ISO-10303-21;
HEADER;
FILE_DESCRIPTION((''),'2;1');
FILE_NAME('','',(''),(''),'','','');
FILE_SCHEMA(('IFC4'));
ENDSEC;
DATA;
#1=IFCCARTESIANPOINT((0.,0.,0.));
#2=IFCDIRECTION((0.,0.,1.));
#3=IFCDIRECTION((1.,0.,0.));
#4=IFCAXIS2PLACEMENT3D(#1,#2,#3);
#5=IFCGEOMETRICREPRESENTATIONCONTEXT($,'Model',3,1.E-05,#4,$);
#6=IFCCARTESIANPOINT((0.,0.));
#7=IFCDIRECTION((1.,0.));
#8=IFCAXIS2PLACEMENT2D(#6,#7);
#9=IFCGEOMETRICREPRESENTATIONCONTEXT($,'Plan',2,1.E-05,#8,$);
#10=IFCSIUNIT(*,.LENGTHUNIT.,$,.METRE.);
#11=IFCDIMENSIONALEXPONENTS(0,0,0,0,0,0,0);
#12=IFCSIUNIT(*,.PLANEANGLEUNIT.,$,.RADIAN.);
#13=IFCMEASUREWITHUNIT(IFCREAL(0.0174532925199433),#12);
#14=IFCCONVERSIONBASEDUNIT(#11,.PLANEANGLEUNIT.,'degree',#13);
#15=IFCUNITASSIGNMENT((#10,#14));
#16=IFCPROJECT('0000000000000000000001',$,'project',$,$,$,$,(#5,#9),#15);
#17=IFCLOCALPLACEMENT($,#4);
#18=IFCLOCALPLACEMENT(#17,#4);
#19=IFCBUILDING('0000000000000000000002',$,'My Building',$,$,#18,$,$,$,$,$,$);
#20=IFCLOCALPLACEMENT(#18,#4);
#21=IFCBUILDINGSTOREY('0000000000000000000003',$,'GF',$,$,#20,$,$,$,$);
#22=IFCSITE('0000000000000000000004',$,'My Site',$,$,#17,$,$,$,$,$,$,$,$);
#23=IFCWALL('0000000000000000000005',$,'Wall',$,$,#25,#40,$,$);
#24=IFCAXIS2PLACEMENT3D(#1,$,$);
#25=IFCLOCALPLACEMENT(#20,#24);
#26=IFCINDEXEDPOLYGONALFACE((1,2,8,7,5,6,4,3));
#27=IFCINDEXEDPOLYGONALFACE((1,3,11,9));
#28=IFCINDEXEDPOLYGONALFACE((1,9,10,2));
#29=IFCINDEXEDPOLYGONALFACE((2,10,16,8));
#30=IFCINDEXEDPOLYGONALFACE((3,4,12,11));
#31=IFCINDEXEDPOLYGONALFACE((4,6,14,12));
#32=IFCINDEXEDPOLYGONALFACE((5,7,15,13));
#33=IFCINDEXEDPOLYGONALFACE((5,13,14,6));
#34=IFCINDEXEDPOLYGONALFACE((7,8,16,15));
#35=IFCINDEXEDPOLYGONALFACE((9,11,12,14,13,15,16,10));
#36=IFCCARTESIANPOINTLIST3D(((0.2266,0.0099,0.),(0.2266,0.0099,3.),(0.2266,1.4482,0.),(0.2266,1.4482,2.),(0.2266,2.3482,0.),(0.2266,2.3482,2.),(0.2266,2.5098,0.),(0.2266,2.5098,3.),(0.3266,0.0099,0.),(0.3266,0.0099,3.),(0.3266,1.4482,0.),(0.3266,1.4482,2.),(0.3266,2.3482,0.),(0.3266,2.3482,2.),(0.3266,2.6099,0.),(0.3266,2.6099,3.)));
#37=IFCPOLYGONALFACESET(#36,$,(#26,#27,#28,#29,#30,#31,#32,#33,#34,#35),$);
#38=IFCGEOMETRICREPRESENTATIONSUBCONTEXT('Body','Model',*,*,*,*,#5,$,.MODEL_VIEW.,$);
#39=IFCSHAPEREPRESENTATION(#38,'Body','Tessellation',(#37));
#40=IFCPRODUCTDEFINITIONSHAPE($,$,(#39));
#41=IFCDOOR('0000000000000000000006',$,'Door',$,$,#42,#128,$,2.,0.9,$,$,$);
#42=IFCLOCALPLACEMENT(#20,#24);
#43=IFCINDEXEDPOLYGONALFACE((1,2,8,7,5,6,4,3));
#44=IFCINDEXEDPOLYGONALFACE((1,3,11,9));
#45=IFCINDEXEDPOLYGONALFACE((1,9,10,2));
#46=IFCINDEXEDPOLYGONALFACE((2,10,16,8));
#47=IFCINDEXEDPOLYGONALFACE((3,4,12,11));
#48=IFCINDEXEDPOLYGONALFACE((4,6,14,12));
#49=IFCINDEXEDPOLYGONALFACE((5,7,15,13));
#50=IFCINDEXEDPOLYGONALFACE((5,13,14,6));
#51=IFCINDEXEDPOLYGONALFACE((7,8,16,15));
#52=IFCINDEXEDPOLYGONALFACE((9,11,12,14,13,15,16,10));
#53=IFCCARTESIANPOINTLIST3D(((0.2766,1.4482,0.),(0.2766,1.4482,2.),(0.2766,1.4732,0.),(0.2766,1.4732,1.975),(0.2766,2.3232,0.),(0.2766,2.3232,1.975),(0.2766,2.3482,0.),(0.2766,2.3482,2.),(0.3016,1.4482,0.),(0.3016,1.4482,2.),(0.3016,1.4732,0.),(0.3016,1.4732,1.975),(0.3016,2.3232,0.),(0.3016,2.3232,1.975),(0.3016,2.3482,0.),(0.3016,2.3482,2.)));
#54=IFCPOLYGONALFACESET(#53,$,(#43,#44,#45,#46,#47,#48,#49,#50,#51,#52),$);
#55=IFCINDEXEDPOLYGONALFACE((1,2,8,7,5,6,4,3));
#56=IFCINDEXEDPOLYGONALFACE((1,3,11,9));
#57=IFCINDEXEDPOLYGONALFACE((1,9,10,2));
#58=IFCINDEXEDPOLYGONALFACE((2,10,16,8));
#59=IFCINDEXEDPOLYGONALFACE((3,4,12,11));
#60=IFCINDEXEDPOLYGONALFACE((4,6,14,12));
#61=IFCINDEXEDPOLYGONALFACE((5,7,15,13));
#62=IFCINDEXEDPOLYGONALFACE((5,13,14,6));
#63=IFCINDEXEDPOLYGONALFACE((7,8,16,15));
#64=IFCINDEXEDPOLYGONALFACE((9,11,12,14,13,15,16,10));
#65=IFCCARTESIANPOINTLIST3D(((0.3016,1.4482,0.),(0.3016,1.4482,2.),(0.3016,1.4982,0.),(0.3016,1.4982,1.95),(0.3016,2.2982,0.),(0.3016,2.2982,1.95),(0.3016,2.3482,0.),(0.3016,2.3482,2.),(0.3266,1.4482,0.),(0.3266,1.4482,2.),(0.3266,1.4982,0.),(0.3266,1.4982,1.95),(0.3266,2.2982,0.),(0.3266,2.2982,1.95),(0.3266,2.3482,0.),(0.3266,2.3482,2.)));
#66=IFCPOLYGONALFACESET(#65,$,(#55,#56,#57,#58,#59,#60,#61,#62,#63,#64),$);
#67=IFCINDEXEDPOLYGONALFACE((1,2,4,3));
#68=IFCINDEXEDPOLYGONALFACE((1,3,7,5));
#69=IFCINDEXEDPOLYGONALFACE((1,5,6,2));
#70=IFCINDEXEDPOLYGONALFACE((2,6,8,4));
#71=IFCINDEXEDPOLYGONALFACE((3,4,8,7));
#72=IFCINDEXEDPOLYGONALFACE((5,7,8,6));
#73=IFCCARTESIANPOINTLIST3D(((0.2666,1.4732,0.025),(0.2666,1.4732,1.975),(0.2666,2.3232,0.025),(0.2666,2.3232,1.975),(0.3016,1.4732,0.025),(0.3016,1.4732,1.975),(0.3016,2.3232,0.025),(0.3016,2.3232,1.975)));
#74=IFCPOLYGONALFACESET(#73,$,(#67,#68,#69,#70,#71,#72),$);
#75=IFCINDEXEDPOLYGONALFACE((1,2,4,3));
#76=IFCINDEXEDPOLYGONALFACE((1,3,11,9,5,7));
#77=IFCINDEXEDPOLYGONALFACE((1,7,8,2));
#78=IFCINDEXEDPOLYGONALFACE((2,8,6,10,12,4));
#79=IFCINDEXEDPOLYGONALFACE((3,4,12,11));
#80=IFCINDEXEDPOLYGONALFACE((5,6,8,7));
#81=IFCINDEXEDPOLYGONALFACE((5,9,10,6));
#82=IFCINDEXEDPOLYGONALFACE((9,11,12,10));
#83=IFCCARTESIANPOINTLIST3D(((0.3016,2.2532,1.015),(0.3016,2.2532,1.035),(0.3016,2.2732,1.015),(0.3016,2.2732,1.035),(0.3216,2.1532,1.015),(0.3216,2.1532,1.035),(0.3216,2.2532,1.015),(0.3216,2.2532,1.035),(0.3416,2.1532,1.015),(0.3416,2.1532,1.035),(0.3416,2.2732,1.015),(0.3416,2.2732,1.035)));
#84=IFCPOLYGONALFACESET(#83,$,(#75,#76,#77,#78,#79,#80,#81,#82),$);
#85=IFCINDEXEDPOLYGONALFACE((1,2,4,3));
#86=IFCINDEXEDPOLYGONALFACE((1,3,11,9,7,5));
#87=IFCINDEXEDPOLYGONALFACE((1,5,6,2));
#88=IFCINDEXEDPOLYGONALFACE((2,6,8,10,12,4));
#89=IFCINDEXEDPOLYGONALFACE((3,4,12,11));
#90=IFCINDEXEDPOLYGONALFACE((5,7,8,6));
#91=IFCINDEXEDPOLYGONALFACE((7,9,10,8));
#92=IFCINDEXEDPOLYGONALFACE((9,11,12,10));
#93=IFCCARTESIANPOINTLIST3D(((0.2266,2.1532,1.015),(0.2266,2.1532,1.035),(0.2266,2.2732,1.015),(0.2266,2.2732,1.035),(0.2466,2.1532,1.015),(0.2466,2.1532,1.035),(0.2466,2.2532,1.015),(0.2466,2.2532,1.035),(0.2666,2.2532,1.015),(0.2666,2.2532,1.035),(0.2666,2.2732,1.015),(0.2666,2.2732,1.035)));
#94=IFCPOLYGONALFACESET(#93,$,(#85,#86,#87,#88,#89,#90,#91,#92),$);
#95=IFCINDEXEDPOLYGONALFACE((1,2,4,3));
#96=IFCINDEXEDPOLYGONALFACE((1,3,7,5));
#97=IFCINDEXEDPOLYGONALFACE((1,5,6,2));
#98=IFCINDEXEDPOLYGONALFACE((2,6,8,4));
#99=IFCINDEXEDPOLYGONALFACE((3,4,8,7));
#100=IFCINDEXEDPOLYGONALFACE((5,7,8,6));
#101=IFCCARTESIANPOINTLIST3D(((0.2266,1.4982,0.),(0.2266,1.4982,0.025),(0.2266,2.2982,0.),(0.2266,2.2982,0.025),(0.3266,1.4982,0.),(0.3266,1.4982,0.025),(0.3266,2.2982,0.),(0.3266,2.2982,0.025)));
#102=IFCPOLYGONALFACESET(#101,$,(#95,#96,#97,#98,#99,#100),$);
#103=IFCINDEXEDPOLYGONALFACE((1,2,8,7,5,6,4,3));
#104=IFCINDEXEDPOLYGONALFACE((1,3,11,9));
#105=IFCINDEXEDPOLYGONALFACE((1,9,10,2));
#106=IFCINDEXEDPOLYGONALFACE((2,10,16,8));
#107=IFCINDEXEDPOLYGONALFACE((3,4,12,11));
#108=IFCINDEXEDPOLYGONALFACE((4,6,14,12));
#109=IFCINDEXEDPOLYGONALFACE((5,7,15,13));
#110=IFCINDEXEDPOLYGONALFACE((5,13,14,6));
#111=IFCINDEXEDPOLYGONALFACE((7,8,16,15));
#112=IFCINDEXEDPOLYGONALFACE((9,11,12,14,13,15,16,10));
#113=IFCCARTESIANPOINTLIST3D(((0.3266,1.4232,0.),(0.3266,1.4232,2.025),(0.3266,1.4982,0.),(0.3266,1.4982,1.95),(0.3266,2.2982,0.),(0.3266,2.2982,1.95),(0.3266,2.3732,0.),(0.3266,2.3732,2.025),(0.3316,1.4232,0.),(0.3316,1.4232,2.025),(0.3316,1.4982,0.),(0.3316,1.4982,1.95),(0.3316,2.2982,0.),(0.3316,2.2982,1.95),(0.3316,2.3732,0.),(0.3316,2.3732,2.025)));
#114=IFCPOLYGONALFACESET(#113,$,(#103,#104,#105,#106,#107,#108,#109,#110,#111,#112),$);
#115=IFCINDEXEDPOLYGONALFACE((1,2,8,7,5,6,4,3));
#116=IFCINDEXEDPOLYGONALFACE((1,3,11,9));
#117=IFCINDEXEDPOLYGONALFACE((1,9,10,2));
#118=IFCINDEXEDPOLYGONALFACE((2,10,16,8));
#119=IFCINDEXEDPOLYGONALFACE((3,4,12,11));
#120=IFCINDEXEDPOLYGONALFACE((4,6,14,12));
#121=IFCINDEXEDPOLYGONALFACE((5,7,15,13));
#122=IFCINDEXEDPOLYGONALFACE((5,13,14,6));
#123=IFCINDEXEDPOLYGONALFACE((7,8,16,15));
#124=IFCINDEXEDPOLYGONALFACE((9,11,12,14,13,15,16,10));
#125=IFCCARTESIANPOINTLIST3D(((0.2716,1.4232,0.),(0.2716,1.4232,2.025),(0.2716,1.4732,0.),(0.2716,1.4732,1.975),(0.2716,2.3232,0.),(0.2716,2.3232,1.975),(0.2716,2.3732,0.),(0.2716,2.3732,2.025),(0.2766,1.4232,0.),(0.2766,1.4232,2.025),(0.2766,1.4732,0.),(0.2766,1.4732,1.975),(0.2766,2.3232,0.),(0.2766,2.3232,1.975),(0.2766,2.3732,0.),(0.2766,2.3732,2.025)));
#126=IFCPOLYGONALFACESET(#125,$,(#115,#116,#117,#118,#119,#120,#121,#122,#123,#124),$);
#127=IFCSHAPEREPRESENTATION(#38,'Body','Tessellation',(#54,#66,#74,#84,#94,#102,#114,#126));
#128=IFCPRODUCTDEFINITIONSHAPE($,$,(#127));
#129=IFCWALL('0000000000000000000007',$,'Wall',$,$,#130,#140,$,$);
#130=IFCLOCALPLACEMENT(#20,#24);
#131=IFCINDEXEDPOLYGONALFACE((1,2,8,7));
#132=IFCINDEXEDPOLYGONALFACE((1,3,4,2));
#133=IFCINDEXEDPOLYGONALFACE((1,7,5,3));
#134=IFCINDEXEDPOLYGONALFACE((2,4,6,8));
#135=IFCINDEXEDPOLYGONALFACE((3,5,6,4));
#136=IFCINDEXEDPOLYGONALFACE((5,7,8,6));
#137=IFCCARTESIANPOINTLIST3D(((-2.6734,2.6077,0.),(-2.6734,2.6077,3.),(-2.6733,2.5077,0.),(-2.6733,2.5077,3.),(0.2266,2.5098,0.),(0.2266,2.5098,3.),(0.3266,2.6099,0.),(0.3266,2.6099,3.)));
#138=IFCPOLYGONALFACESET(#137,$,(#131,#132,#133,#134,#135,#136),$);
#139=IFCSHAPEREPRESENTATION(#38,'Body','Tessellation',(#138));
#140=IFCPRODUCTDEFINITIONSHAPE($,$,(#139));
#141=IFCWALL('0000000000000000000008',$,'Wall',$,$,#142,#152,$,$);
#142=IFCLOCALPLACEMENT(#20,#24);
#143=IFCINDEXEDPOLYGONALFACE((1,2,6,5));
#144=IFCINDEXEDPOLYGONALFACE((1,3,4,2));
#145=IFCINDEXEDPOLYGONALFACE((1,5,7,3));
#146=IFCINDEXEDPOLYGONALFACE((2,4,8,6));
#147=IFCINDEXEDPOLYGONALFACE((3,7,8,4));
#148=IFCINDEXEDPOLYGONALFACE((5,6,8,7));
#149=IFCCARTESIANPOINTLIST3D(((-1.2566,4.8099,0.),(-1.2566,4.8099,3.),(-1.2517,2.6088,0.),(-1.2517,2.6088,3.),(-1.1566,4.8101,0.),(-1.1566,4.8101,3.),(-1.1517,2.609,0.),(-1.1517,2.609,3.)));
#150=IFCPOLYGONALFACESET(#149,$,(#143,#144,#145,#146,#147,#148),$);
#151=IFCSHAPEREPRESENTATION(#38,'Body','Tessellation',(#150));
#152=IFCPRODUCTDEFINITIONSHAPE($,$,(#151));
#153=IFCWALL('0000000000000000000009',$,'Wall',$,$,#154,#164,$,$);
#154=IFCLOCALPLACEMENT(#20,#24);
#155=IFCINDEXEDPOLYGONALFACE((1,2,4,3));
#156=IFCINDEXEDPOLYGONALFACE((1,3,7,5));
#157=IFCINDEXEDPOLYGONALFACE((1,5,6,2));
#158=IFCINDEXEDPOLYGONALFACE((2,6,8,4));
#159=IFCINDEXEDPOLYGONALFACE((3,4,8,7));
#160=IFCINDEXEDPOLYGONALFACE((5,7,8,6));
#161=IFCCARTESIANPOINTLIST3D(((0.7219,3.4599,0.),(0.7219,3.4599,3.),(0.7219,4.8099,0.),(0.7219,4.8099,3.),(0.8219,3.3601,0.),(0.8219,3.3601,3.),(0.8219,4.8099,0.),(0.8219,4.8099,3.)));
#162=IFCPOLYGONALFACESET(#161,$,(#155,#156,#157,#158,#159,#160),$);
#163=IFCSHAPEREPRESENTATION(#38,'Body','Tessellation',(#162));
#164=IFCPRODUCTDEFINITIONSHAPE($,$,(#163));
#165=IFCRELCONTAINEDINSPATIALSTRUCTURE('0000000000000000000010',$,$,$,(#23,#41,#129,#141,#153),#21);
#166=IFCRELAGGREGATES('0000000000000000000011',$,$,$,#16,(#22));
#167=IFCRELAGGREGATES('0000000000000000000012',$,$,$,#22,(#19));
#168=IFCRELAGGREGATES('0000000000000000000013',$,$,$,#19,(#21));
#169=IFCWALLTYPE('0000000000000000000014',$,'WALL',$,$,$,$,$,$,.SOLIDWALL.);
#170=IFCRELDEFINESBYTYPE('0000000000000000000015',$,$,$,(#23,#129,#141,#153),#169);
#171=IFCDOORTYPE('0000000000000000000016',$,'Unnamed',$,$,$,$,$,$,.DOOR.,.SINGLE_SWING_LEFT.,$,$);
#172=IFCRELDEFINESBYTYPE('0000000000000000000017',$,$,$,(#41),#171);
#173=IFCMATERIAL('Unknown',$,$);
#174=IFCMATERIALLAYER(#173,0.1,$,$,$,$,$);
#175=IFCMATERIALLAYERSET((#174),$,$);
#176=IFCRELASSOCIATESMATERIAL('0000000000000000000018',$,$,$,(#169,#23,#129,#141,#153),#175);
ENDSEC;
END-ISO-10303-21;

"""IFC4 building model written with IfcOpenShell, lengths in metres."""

from ifc_helpers import new_model, entity, si_unit, converted_unit, frame, origin_with_axes, origin_2d_with_axis, place, context, subcontext, project, spatial, line, indexed_curve, outline, extrude, shape, source, transform, mapped, material, layer, layer_set, layer_usage, type_object, type_shapes, element, fill, save


model = new_model("IFC4")

# Units and contexts
model_context = context("Model", 3, precision=1e-05, world=origin_with_axes())
plan_context = context("Plan", 2, precision=1e-05, world=origin_2d_with_axis())
body_context_1 = subcontext(model_context, "Body", "Model", "MODEL_VIEW")
body_context_2 = subcontext(plan_context, "Body", "Plan", "PLAN_VIEW")
ifc_project = project(units=[si_unit("LENGTHUNIT", "METRE"), converted_unit("PLANEANGLEUNIT", "degree", entity("IfcReal", 0.0174532925199433), si_unit("PLANEANGLEUNIT", "RADIAN"), dimensions=[0, 0, 0, 0, 0, 0, 0])], contexts=[model_context, plan_context])

# Site, building, storey
site_placement = place(None, origin_with_axes())
site = spatial("IfcSite", under=ifc_project, at=site_placement, Name="My Site")
building_placement = place(site_placement, origin_with_axes())
building = spatial("IfcBuilding", under=site, at=building_placement, Name="My Building")
storey_placement = place(building_placement, origin_with_axes())
storey = spatial("IfcBuildingStorey", under=building, at=storey_placement, Name="GF")

# Shared definitions
ifc_material_1 = material(Name="Unknown")

# Shared definitions
ifc_layer_1 = layer(ifc_material_1, 0.1)
ifc_layer_set_1 = layer_set([ifc_layer_1])
wall_type = type_object("IfcWallType", Name="WALL", PredefinedType="SOLIDWALL", material=ifc_layer_set_1)

# Wall, opening, door
ifc_layer_usage_1 = layer_usage(ifc_layer_set_1, "AXIS2", "POSITIVE", 0.0)
wall_1_placement = place(storey_placement, frame((0.3266, 0.0099, 0.0), z_axis=(0.0, 0.0, 1.0), x_axis=(0.0, 1.0, 0.0)))
wall_1 = element("IfcWall", 1, at=wall_1_placement, inside=storey, type_object=wall_type, material=ifc_layer_usage_1, Name="Wall", context=body_context_1, shape_type="SweptSolid", body=[
    extrude(outline(indexed_curve([(0.0, 0.0), (0.0, 0.1), (2.4999, 0.1), (2.6, 0.0)], segments=[line(1, 2, 3, 4, 1)])), origin_with_axes(), (0.0, 0.0, 1.0), 3.0),
])
shared_shape_1 = source(origin_with_axes(), body_context_1, "Body", "SweptSolid", [
    extrude(outline(indexed_curve([(0.0, 0.0), (0.9, 0.0), (0.9, 2.0), (0.0, 2.0)], segments=[line(1, 2, 3, 4, 1)])), frame((0.0, -0.6, 0.0), z_axis=(0.0, -1.0, 0.0), x_axis=(1.0, 0.0, 0.0)), (0.0, 0.0, -1.0), 1.2),
])
opening_1_placement = place(wall_1_placement, frame((1.4383, 0.0, 0.0), z_axis=(0.0, 0.0, 1.0), x_axis=(1.0, 0.0, 0.0)))
opening_1 = element("IfcOpeningElement", 2, at=opening_1_placement, cuts=wall_1, PredefinedType="OPENING", context=body_context_1, shape_type="MappedRepresentation", body=[
    mapped(shared_shape_1, transform((0.0, 0.0, 0.0), x_axis=(1.0, 0.0, 0.0), y_axis=(0.0, 1.0, 0.0), z_axis=(0.0, 0.0, 1.0), scale=1.0)),
])
door_type = type_object("IfcDoorType", Name="Unnamed", OperationType="SINGLE_SWING_LEFT", PredefinedType="DOOR")
shared_shape_2 = source(origin_with_axes(), body_context_1, "Body", "SweptSolid", [
    extrude(outline(indexed_curve([(0.0, 0.0), (0.0, 2.0), (0.9, 2.0), (0.9, 0.0), (0.875, 0.0), (0.875, 1.975), (0.025, 1.975), (0.025, 0.0)], segments=[line(1, 2, 3, 4, 5, 6, 7, 8, 1)])), frame((0.0, 0.025, 0.0), z_axis=(0.0, -1.0, 0.0), x_axis=(1.0, 0.0, 0.0)), (0.0, 0.0, -1.0), 0.025),
    extrude(outline(indexed_curve([(0.0, 0.0), (0.0, 2.0), (0.9, 2.0), (0.9, 0.0), (0.85, 0.0), (0.85, 1.95), (0.05, 1.95), (0.05, 0.0)], segments=[line(1, 2, 3, 4, 5, 6, 7, 8, 1)])), frame((0.0, 0.0, 0.0), z_axis=(0.0, -1.0, 0.0), x_axis=(1.0, 0.0, 0.0)), (0.0, 0.0, -1.0), 0.025),
    extrude(outline(indexed_curve([(0.0, 0.0), (0.85, 0.0), (0.85, 0.035), (0.0, 0.035)], segments=[line(1, 2, 3, 4, 1)])), frame((0.025, 0.025, 0.025), z_axis=(0.0, 0.0, 1.0), x_axis=(1.0, 0.0, 0.0)), (0.0, 0.0, 1.0), 1.95),
    extrude(outline(indexed_curve([(0.0, 0.0), (0.0, -0.04), (-0.12, -0.04), (-0.12, -0.02), (-0.02, -0.02), (-0.02, 0.0)], segments=[line(1, 2, 3, 4, 5, 6, 1)])), frame((0.825, 0.025, 1.015), z_axis=(0.0, 0.0, 1.0), x_axis=(1.0, 0.0, 0.0)), (0.0, 0.0, 1.0), 0.02),
    extrude(outline(indexed_curve([(0.0, 0.0), (0.0, 0.04), (-0.12, 0.04), (-0.12, 0.02), (-0.02, 0.02), (-0.02, 0.0)], segments=[line(1, 2, 3, 4, 5, 6, 1)])), frame((0.825, 0.06, 1.015), z_axis=(0.0, 0.0, 1.0), x_axis=(1.0, 0.0, 0.0)), (0.0, 0.0, 1.0), 0.02),
    extrude(outline(indexed_curve([(0.0, 0.0), (0.8, 0.0), (0.8, 0.1), (0.0, 0.1)], segments=[line(1, 2, 3, 4, 1)])), frame((0.05, 0.0, 0.0), z_axis=(0.0, 0.0, 1.0), x_axis=(1.0, 0.0, 0.0)), (0.0, 0.0, 1.0), 0.025),
    extrude(outline(indexed_curve([(0.0, 0.0), (0.0, 2.025), (0.95, 2.025), (0.95, 0.0), (0.875, 0.0), (0.875, 1.95), (0.075, 1.95), (0.075, 0.0)], segments=[line(1, 2, 3, 4, 5, 6, 7, 8, 1)])), frame((-0.025, -0.005, 0.0), z_axis=(0.0, -1.0, 0.0), x_axis=(1.0, 0.0, 0.0)), (0.0, 0.0, -1.0), 0.005),
    extrude(outline(indexed_curve([(0.0, 0.0), (0.0, 2.025), (0.95, 2.025), (0.95, 0.0), (0.9, 0.0), (0.9, 1.975), (0.05, 1.975), (0.05, 0.0)], segments=[line(1, 2, 3, 4, 5, 6, 7, 8, 1)])), frame((-0.025, 0.05, 0.0), z_axis=(0.0, -1.0, 0.0), x_axis=(1.0, 0.0, 0.0)), (0.0, 0.0, -1.0), 0.005),
])
shared_shape_3 = source(origin_with_axes(), body_context_2, "Body", "Curve2D", [
    entity("IfcIndexedPolyCurve", entity("IfcCartesianPointList2D", [[0.0, 0.0], [0.0, 0.05], [0.025, 0.05], [0.025, 0.025], [0.05, 0.025], [0.05, 0.0]]), [entity("IfcLineIndex", [1, 2, 3, 4, 5, 6, 1])]),
    entity("IfcIndexedPolyCurve", entity("IfcCartesianPointList2D", [[0.9, 0.0], [0.9, 0.05], [0.875, 0.05], [0.875, 0.025], [0.85, 0.025], [0.85, 0.0]]), [entity("IfcLineIndex", [1, 2, 3, 4, 5, 6, 1])]),
    entity("IfcTrimmedCurve", entity("IfcEllipse", entity("IfcAxis2Placement2D", entity("IfcCartesianPoint", [0.06, 0.05]), entity("IfcDirection", [1.0, 0.0])), 0.815, 0.85), [entity("IfcCartesianPoint", [0.875, 0.05])], [entity("IfcCartesianPoint", [0.06, 0.9])], True, "CARTESIAN"),
    entity("IfcIndexedPolyCurve", entity("IfcCartesianPointList2D", [[0.025, 0.05], [0.06, 0.05], [0.06, 0.9], [0.025, 0.9]]), [entity("IfcLineIndex", [1, 2, 3, 4, 1])]),
])
type_shapes(door_type, [shared_shape_2, shared_shape_3])
door_1_placement = place(opening_1_placement, frame((0.0, 0.0, 0.0), z_axis=(0.0, 0.0, 1.0), x_axis=(1.0, 0.0, 0.0)))
door_1 = element("IfcDoor", 3, at=door_1_placement, inside=storey, type_object=door_type, Name="Door", OverallHeight=2.0, OverallWidth=0.9, shapes=[
    shape(body_context_1, "Body", "MappedRepresentation", [mapped(shared_shape_2, transform((0.0, 0.0, 0.0), x_axis=(1.0, 0.0, 0.0), y_axis=(0.0, 1.0, 0.0), z_axis=(0.0, 0.0, 1.0), scale=1.0))]),
    shape(body_context_2, "Body", "MappedRepresentation", [mapped(shared_shape_3, transform((0.0, 0.0, 0.0), x_axis=(1.0, 0.0, 0.0), y_axis=(0.0, 1.0, 0.0), z_axis=(0.0, 0.0, 1.0), scale=1.0))]),
])
fill(opening_1, door_1)

# Walls
ifc_layer_usage_2 = layer_usage(ifc_layer_set_1, "AXIS2", "POSITIVE", 0.0)
wall_2_placement = place(storey_placement, frame((0.3266, 2.6099, 0.0), z_axis=(0.0, 0.0, 1.0), x_axis=(-1.0, -0.000723, 0.0)))
element("IfcWall", 4, at=wall_2_placement, inside=storey, type_object=wall_type, material=ifc_layer_usage_2, Name="Wall", context=body_context_1, shape_type="SweptSolid", body=[
    extrude(outline(indexed_curve([(0.0, 0.0), (0.1001, 0.1), (3.0, 0.1), (3.0, 0.0)], segments=[line(1, 2, 3, 4, 1)])), origin_with_axes(), (0.0, 0.0, 1.0), 3.0),
])
ifc_layer_usage_3 = layer_usage(ifc_layer_set_1, "AXIS2", "POSITIVE", 0.0)
wall_3_placement = place(storey_placement, frame((-1.2566, 4.8099, 0.0), z_axis=(0.0, 0.0, 1.0), x_axis=(0.002212, -0.999998, 0.0)))
element("IfcWall", 5, at=wall_3_placement, inside=storey, type_object=wall_type, material=ifc_layer_usage_3, Name="Wall", context=body_context_1, shape_type="SweptSolid", body=[
    extrude(outline(indexed_curve([(0.0, 0.0), (0.0, 0.1), (2.2011, 0.1), (2.2011, 0.0)], segments=[line(1, 2, 3, 4, 1)])), origin_with_axes(), (0.0, 0.0, 1.0), 3.0),
])
ifc_layer_usage_4 = layer_usage(ifc_layer_set_1, "AXIS2", "POSITIVE", 0.0)
wall_4_placement = place(storey_placement, frame((0.7219, 4.8099, 0.0), z_axis=(0.0, 0.0, 1.0), x_axis=(0.0, -1.0, 0.0)))
element("IfcWall", 6, at=wall_4_placement, inside=storey, type_object=wall_type, material=ifc_layer_usage_4, Name="Wall", context=body_context_1, shape_type="SweptSolid", body=[
    extrude(outline(indexed_curve([(0.0, 0.0), (0.0, 0.1), (1.4498, 0.1), (1.35, 0.0)], segments=[line(1, 2, 3, 4, 1)])), origin_with_axes(), (0.0, 0.0, 1.0), 3.0),
])

save(model, "model.ifc")
